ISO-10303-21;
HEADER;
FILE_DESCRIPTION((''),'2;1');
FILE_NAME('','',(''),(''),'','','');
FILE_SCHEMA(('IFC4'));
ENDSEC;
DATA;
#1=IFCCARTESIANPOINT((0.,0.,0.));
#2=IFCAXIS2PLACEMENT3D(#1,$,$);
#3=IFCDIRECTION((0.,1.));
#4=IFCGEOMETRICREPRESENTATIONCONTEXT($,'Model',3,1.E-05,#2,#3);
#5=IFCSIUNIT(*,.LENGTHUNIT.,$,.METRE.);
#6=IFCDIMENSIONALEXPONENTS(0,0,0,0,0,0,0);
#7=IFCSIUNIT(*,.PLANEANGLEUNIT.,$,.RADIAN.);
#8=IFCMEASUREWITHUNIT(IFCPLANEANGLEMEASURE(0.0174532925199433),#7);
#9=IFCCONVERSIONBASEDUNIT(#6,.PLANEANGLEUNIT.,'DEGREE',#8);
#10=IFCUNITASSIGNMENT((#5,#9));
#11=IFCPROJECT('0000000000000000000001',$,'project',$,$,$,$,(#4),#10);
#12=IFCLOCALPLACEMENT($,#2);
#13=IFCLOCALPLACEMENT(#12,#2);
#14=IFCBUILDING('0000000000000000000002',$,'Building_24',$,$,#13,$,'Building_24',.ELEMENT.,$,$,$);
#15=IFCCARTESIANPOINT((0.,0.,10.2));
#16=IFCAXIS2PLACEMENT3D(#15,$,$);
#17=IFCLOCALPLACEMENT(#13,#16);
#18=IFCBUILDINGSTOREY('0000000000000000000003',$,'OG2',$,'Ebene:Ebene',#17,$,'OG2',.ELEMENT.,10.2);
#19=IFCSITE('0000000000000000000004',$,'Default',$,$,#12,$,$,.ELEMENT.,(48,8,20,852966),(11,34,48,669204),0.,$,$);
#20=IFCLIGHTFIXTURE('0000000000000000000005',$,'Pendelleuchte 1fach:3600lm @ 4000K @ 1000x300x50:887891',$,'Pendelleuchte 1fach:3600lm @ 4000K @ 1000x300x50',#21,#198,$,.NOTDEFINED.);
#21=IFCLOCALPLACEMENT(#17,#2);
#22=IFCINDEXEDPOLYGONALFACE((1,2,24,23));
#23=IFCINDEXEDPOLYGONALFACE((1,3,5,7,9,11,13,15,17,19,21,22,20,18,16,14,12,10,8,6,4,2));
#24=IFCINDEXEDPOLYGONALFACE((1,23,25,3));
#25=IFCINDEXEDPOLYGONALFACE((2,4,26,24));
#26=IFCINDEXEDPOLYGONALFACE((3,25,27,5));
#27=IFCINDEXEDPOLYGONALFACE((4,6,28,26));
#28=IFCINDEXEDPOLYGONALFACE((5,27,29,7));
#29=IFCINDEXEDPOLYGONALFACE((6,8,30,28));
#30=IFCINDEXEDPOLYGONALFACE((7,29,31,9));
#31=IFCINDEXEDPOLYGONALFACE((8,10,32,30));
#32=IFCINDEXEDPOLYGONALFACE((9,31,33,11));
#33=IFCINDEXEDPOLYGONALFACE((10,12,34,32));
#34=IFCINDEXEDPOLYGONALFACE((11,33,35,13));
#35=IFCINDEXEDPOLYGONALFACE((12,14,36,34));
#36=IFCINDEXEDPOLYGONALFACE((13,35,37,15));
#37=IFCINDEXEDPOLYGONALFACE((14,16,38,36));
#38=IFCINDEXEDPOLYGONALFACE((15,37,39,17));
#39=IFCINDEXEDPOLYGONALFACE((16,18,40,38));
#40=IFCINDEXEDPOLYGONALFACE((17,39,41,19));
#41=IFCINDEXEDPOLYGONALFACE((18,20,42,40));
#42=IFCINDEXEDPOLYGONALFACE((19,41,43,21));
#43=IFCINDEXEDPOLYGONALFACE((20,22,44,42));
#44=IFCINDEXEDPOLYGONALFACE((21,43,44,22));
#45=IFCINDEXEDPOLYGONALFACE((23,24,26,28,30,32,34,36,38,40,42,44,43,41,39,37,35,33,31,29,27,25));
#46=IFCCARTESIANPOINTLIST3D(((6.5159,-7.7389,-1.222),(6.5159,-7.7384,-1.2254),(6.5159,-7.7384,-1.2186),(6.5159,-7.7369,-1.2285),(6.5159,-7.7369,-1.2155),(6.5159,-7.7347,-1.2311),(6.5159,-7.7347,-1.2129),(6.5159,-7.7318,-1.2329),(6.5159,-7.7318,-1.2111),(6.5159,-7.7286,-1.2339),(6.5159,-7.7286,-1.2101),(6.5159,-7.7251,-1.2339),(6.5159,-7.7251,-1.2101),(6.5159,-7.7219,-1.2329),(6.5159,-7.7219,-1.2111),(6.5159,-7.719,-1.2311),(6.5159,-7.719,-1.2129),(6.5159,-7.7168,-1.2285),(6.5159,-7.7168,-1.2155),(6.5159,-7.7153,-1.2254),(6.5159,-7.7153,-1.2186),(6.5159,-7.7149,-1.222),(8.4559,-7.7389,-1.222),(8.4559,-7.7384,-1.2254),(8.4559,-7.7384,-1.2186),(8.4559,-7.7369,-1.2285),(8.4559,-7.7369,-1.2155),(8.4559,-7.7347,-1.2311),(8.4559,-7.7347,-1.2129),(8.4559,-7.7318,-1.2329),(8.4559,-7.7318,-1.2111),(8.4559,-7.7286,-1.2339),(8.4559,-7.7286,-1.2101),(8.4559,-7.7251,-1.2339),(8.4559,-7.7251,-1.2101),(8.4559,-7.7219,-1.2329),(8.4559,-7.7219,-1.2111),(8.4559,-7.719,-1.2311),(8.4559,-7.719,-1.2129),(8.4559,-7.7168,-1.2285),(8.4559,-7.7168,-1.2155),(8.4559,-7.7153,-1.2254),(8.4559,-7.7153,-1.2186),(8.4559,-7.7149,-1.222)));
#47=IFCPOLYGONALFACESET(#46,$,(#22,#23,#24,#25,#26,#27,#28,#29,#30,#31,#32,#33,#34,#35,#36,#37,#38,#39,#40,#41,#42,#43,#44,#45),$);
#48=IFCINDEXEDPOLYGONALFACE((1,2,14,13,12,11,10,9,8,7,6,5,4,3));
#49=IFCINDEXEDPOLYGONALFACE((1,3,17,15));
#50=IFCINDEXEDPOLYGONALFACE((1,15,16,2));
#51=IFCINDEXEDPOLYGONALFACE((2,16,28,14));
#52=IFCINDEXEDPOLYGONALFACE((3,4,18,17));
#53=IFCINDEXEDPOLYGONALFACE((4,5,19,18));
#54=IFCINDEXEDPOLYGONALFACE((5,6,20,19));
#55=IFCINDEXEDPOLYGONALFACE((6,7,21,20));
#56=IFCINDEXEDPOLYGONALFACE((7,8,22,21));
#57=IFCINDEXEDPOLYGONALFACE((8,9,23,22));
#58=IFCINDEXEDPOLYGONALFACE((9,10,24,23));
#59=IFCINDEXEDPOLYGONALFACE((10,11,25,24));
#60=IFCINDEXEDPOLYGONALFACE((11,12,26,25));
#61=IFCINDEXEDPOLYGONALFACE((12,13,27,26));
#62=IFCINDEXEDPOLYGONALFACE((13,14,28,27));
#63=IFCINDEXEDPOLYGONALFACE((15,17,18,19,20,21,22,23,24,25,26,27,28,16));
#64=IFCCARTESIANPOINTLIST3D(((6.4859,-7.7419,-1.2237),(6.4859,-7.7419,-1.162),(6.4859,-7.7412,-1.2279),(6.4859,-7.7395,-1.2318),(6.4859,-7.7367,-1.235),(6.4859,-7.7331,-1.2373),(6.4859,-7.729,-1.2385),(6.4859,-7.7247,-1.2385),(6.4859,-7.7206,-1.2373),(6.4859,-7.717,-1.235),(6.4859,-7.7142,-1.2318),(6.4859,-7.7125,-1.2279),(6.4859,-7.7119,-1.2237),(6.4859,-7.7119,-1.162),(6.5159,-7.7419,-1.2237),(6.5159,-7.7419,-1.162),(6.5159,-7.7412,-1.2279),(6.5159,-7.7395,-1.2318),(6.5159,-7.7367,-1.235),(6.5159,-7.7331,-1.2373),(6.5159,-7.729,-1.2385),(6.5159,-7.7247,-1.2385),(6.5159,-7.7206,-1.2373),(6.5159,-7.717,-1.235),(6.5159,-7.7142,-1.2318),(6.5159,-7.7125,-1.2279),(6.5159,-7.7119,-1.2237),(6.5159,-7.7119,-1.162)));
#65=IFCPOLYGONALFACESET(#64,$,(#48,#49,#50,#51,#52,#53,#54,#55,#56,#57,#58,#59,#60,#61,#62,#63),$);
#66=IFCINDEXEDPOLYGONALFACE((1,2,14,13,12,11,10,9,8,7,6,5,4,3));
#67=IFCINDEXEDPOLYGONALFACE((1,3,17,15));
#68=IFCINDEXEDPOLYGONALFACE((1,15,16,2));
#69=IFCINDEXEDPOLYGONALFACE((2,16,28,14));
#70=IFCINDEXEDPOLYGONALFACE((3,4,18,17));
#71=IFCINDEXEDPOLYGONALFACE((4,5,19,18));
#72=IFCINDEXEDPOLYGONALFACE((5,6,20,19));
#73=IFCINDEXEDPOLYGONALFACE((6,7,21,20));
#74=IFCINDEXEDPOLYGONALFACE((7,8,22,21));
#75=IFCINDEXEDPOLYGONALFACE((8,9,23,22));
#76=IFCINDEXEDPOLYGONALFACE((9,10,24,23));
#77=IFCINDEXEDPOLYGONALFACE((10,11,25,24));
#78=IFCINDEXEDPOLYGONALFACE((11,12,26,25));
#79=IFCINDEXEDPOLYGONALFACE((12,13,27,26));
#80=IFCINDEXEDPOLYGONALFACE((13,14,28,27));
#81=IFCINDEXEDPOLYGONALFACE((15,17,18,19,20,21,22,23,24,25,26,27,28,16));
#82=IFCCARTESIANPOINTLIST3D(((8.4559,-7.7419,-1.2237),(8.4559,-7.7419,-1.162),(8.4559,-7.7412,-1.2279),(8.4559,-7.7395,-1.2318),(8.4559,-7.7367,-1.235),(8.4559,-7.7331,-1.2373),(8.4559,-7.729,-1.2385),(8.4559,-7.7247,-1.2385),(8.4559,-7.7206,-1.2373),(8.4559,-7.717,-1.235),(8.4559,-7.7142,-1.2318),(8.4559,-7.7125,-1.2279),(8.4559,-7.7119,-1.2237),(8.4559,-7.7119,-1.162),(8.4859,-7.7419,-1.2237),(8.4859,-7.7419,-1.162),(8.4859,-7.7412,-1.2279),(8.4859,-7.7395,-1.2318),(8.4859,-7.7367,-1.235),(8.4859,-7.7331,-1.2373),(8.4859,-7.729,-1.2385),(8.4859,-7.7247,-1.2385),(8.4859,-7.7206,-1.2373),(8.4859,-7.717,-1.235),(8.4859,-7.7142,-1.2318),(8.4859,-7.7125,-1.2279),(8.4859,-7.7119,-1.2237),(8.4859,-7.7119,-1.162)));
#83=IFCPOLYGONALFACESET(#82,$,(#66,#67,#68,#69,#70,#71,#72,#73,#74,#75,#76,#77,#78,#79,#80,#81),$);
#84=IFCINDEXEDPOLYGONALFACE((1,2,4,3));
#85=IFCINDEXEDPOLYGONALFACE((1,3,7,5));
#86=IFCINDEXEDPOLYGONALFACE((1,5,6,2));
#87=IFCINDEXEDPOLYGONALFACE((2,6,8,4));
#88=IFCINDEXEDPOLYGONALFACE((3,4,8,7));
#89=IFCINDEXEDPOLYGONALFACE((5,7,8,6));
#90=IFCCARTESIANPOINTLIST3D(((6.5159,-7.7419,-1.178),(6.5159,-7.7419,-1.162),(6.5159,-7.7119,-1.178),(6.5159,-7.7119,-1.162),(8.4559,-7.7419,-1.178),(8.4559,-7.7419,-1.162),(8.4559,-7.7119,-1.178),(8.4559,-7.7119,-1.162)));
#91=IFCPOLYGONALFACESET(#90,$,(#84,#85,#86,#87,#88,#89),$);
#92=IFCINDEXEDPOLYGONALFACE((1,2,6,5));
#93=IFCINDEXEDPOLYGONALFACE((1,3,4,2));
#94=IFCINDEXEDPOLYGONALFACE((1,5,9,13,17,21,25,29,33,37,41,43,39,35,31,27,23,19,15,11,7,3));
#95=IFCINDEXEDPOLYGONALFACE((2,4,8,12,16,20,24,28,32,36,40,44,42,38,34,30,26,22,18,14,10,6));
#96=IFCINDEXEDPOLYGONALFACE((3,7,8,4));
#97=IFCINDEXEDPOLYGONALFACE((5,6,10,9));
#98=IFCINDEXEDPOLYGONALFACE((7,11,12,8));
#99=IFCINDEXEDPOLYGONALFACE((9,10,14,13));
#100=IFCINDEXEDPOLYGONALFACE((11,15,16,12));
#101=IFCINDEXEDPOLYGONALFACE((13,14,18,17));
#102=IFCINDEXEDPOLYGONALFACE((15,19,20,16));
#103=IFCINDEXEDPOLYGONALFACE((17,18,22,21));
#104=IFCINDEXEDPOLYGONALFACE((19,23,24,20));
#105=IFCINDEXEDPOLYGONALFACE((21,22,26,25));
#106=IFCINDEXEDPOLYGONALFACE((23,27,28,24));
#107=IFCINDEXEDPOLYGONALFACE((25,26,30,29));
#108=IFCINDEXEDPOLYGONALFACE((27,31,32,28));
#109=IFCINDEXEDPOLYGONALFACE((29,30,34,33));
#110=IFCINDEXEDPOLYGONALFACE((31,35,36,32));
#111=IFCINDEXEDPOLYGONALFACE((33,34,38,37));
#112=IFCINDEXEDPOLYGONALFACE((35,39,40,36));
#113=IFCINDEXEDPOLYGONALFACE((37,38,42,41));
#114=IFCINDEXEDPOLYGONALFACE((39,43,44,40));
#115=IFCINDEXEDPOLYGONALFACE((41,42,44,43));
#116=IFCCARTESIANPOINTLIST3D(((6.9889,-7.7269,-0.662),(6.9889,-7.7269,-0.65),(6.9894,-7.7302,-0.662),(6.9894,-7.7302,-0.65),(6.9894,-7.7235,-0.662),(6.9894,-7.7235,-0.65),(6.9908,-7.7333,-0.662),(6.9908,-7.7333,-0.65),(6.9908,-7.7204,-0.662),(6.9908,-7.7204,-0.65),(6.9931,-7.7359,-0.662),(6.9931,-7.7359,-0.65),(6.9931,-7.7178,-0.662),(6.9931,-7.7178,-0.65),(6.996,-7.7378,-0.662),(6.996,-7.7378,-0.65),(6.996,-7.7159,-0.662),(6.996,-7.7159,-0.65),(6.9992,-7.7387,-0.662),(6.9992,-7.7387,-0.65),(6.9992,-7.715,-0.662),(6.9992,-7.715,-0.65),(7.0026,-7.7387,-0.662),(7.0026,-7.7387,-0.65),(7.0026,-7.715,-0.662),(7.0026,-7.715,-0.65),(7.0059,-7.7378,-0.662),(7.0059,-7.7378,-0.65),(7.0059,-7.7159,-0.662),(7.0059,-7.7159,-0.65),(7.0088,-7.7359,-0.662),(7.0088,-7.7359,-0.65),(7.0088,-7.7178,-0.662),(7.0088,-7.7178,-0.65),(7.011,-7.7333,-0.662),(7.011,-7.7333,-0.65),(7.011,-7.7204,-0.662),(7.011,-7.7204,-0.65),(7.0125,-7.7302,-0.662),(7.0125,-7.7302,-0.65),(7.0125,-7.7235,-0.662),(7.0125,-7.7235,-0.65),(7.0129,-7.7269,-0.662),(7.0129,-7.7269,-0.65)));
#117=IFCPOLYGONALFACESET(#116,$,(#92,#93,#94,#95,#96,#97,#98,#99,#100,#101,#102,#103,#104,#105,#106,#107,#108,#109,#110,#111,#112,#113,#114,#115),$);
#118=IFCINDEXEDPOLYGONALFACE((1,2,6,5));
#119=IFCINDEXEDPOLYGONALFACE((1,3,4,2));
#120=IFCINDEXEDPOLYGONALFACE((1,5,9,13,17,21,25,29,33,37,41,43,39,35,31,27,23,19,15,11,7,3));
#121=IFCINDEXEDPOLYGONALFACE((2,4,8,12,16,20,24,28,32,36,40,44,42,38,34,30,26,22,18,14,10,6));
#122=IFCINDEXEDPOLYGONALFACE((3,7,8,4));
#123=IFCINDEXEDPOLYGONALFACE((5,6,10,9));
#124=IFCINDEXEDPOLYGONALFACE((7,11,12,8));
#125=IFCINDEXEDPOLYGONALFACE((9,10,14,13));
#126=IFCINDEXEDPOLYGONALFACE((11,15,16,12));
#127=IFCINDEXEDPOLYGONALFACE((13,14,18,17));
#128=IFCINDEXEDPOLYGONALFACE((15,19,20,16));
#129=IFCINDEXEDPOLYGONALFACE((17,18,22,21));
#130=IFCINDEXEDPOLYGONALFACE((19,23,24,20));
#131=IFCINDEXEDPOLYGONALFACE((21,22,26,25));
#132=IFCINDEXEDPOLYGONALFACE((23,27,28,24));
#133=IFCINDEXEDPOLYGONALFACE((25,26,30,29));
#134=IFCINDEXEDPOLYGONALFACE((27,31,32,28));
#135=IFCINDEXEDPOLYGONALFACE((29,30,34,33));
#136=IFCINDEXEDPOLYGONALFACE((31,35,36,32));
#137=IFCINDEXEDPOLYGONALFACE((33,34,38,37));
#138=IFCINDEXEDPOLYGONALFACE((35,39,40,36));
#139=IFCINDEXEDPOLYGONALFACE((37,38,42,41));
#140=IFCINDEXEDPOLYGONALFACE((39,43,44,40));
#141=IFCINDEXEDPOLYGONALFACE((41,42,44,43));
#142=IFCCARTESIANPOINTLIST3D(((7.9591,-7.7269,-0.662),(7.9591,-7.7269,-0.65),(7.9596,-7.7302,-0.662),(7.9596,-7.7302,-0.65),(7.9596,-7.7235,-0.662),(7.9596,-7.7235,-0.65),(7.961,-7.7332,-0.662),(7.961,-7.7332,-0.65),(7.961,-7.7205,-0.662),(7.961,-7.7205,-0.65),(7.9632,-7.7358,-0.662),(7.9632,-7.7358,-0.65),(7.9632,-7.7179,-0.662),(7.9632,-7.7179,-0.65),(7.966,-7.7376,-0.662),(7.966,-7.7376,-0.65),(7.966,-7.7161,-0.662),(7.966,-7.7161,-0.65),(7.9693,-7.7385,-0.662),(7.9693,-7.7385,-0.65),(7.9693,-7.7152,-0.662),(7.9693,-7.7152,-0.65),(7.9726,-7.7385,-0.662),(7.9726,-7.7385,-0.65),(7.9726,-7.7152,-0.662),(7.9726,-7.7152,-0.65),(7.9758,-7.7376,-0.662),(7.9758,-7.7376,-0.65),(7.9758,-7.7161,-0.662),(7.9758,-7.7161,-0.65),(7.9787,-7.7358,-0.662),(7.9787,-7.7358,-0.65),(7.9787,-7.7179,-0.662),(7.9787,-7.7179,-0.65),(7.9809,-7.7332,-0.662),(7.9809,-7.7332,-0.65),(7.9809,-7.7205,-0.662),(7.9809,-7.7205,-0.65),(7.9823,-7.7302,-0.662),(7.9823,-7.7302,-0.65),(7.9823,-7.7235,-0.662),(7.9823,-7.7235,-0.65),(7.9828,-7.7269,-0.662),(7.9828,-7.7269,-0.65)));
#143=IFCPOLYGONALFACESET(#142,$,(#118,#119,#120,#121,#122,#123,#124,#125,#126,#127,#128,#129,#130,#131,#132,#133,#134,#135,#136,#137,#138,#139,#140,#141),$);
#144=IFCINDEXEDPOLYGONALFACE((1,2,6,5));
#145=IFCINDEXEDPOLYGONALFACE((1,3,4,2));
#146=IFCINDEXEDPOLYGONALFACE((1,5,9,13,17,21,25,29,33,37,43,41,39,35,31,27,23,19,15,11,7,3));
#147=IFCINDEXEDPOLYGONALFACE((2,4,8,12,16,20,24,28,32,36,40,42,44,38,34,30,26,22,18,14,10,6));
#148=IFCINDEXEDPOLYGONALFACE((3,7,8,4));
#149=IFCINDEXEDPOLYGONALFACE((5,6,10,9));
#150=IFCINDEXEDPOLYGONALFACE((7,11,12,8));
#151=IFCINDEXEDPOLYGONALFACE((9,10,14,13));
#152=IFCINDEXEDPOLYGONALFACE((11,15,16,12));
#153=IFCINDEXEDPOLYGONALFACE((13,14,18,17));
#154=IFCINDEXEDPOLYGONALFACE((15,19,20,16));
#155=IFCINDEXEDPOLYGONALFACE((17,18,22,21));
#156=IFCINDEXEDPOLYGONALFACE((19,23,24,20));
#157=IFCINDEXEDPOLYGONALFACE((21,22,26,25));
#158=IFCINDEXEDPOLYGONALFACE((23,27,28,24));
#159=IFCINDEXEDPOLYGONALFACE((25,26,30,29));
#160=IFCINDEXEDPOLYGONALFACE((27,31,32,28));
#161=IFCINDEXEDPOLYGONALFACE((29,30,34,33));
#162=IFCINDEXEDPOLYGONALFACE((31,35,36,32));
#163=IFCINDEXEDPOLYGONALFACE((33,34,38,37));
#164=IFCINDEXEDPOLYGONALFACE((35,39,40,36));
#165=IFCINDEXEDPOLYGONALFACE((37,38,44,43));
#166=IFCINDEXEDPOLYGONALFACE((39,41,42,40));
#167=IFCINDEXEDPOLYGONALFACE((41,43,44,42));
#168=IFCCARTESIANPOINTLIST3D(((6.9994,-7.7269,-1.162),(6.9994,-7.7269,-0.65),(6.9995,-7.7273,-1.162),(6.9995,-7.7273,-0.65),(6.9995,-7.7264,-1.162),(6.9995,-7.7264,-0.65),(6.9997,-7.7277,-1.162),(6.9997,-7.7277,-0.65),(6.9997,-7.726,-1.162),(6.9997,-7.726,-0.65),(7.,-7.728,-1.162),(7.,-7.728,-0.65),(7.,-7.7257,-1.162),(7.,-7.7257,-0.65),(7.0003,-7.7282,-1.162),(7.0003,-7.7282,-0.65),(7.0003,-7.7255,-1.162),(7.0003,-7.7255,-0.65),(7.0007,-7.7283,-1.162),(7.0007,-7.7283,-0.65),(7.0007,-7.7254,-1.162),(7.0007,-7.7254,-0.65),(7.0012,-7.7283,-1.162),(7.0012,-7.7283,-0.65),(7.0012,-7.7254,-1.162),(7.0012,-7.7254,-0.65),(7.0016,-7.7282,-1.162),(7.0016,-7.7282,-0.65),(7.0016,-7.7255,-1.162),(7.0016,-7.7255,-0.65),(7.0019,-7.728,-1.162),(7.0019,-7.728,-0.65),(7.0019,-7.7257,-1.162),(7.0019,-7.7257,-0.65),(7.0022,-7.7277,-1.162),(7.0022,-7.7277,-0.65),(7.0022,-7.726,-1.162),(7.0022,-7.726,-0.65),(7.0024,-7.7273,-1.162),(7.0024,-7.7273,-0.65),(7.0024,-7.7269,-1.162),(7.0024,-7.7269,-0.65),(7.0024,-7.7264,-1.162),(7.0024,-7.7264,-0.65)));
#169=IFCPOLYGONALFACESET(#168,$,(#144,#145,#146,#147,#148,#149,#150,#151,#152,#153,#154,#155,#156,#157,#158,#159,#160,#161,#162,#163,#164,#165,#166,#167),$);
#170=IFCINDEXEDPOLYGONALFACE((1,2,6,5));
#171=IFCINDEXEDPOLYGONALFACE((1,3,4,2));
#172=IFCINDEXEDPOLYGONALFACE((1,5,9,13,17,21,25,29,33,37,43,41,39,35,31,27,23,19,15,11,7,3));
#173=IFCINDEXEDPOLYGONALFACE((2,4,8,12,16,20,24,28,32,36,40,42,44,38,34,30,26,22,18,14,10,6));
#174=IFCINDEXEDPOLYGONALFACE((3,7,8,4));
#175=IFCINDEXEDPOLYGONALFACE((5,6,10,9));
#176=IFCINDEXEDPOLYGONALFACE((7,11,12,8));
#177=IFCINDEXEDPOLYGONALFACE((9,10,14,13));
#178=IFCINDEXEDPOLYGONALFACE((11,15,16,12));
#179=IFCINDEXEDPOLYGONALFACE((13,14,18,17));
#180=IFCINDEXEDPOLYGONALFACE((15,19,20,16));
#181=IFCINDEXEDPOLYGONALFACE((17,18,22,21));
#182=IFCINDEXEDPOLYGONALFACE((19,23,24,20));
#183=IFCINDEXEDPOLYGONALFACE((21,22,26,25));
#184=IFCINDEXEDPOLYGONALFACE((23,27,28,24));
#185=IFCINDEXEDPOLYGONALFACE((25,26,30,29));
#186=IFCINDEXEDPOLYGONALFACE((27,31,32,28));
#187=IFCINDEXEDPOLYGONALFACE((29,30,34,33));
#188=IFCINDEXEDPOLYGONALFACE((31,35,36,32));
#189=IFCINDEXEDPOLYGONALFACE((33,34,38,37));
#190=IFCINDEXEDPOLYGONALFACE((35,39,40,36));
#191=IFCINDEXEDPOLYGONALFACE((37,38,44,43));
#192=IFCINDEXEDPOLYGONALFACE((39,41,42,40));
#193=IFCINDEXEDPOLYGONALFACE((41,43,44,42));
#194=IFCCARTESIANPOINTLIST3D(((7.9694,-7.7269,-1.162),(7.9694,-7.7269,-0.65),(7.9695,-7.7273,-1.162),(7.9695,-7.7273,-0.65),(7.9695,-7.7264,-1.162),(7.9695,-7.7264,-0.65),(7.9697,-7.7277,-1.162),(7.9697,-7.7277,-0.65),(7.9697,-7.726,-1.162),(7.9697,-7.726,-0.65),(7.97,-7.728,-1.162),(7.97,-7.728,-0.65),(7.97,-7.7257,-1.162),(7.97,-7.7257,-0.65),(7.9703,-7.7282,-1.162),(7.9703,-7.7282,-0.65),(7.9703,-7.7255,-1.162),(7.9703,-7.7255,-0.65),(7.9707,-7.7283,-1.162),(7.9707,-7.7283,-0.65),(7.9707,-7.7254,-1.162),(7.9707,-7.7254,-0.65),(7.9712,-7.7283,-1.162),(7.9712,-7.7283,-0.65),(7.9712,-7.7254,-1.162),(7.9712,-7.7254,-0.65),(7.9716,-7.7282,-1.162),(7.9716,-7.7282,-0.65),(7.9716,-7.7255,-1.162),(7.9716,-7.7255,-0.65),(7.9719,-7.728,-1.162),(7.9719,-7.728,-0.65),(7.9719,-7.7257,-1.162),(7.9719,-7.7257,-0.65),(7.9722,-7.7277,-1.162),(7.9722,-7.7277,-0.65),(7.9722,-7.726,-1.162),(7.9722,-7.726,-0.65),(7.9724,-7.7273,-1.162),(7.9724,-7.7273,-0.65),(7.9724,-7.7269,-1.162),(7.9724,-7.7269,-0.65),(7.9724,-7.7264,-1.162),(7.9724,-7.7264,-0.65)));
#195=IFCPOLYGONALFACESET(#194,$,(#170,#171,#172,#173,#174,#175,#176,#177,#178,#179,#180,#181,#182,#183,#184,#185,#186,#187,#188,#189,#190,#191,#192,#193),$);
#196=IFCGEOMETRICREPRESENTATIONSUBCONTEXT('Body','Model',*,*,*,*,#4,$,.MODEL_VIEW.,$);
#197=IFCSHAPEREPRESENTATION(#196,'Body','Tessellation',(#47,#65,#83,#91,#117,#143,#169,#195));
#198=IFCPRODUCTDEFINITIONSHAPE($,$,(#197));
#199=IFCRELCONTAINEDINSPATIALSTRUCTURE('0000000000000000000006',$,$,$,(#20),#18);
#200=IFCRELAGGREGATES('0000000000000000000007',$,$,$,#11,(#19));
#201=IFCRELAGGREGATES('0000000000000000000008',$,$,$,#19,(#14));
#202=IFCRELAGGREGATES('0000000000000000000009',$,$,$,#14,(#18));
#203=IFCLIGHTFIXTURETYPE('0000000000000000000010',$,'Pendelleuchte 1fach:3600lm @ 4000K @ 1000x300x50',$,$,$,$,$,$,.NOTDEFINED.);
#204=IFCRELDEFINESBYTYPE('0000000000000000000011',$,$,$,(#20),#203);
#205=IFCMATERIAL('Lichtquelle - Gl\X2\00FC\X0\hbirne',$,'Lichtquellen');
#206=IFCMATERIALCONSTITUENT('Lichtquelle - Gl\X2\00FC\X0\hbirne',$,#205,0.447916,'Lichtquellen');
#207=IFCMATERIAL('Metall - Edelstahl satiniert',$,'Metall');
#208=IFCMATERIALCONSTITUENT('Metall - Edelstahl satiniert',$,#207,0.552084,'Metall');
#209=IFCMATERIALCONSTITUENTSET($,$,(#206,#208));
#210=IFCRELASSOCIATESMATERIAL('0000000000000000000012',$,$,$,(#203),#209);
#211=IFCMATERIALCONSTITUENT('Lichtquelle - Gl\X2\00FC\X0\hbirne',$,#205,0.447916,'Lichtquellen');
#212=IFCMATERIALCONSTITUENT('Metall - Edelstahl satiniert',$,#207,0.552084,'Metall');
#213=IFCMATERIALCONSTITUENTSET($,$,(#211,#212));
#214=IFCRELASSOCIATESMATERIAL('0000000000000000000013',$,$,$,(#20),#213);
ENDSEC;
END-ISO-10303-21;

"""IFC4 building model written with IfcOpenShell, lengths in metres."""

from ifc_helpers import new_model, entity, si_unit, converted_unit, direction, frame, origin, place, context, subcontext, project, spatial, line, arc, indexed_curve, outline, extrude, source, transform, mapped, material, constituent, constituent_set, type_object, type_shapes, element, save


model = new_model("IFC4")

# Units and contexts
model_context = context("Model", 3, precision=1e-05, world=origin(), true_north=direction((0.0, 1.0)))
body_context = subcontext(model_context, "Body", "Model", "MODEL_VIEW")
ifc_project = project(units=[si_unit("LENGTHUNIT", "METRE"), converted_unit("PLANEANGLEUNIT", "DEGREE", entity("IfcPlaneAngleMeasure", 0.0174532925199433), si_unit("PLANEANGLEUNIT", "RADIAN"), dimensions=[0, 0, 0, 0, 0, 0, 0])], contexts=[model_context])

# Site, building, storey
site_placement = place(None, origin())
site = spatial("IfcSite", under=ifc_project, at=site_placement, Name="Default", CompositionType="ELEMENT", RefLatitude=(48, 8, 20, 852966), RefLongitude=(11, 34, 48, 669204), RefElevation=0.0)
building_placement = place(site_placement, origin())
building = spatial("IfcBuilding", under=site, at=building_placement, Name="Building_24", LongName="Building_24", CompositionType="ELEMENT")
storey_placement = place(building_placement, frame((0.0, 0.0, 10.2)))
storey = spatial("IfcBuildingStorey", under=building, at=storey_placement, Name="OG2", ObjectType="Ebene:Ebene", LongName="OG2", CompositionType="ELEMENT", Elevation=10.2)

# Light fixture
ifc_material_1 = material(Name="Lichtquelle - Glühbirne", Category="Lichtquellen")
ifc_material_2 = material(Name="Metall - Edelstahl satiniert", Category="Metall")
ifc_constituent_1 = constituent(ifc_material_1, Name="Lichtquelle - Glühbirne", Category="Lichtquellen", fraction=0.447916)
ifc_constituent_2 = constituent(ifc_material_2, Name="Metall - Edelstahl satiniert", Category="Metall", fraction=0.552084)
ifc_constituent_set_1 = constituent_set(constituents=[ifc_constituent_1, ifc_constituent_2])
light_fixture_type_1 = type_object("IfcLightFixtureType", Name="Pendelleuchte 1fach:3600lm @ 4000K @ 1000x300x50", PredefinedType="NOTDEFINED", material=ifc_constituent_set_1)
shared_shape_1 = source(origin(), body_context, "Body", "SweptSolid", [
    extrude(outline(indexed_curve([(-0.012, 0.0), (0.0, -0.012), (0.012, 0.0), (0.0, 0.012)], segments=[arc(1, 2, 3), arc(3, 4, 1)], self_intersect=False)), frame((-0.97, 0.0, -0.572), z_axis=(1.0, 0.0, 0.0), x_axis=(0.0, 1.0, 0.0)), (0.0, 0.0, 1.0), 1.94),
    extrude(outline(indexed_curve([(-0.0308, -0.015), (0.0308, -0.015), (0.0308, 0.015), (-0.0308, 0.015), (-0.0458, 0.0)], segments=[line(1, 2, 3, 4), arc(4, 5, 1)], self_intersect=False)), frame((0.97, 0.0, -0.5428), z_axis=(1.0, 0.0, 0.0), x_axis=(0.0, 0.0, 1.0)), (0.0, 0.0, 1.0), 0.03),
    extrude(outline(indexed_curve([(-0.0308, -0.015), (0.0308, -0.015), (0.0308, 0.015), (-0.0308, 0.015), (-0.0458, 0.0)], segments=[line(1, 2, 3, 4), arc(4, 5, 1)], self_intersect=False)), frame((-1.0, 0.0, -0.5428), z_axis=(1.0, 0.0, 0.0), x_axis=(0.0, 0.0, 1.0)), (0.0, 0.0, 1.0), 0.03),
    extrude(outline(indexed_curve([(-0.97, -0.015), (0.97, -0.015), (0.97, 0.015), (-0.97, 0.015), (-0.97, -0.015)], self_intersect=False)), frame((0.0, 0.0, -0.528), z_axis=(0.0, 0.0, 1.0), x_axis=(-1.0, 0.0, 0.0)), (0.0, 0.0, 1.0), 0.016),
    extrude(outline(indexed_curve([(-0.012, 0.0), (0.0, -0.012), (0.012, 0.0), (0.0, 0.012)], segments=[arc(1, 2, 3), arc(3, 4, 1)], self_intersect=False)), frame((0.485, 0.0, -0.012)), (0.0, 0.0, 1.0), 0.012),
    extrude(outline(indexed_curve([(-0.0118, 0.0), (0.0, -0.0118), (0.0118, 0.0), (0.0, 0.0118)], segments=[arc(1, 2, 3), arc(3, 4, 1)], self_intersect=False)), frame((-0.485, 0.0, -0.012)), (0.0, 0.0, 1.0), 0.012),
    extrude(outline(indexed_curve([(-0.0015, 0.0), (0.0, -0.0015), (0.0015, 0.0), (0.0, 0.0015)], segments=[arc(1, 2, 3), arc(3, 4, 1)], self_intersect=False)), frame((0.485, 0.0, -0.512)), (0.0, 0.0, 1.0), 0.512),
    extrude(outline(indexed_curve([(-0.0015, 0.0), (0.0, -0.0015), (0.0015, 0.0), (0.0, 0.0015)], segments=[arc(1, 2, 3), arc(3, 4, 1)], self_intersect=False)), frame((-0.485, 0.0, -0.512)), (0.0, 0.0, 1.0), 0.512),
])
type_shapes(light_fixture_type_1, [shared_shape_1])
ifc_constituent_3 = constituent(ifc_material_1, Name="Lichtquelle - Glühbirne", Category="Lichtquellen", fraction=0.447916)
ifc_constituent_4 = constituent(ifc_material_2, Name="Metall - Edelstahl satiniert", Category="Metall", fraction=0.552084)
ifc_constituent_set_2 = constituent_set(constituents=[ifc_constituent_3, ifc_constituent_4])
light_fixture_1_placement = place(storey_placement, frame((7.4859, -7.7269, -0.65), z_axis=(0.0, 0.0, 1.0), x_axis=(-1.0, 0.0, 0.0)))
element("IfcLightFixture", 1, at=light_fixture_1_placement, inside=storey, type_object=light_fixture_type_1, material=ifc_constituent_set_2, Name="Pendelleuchte 1fach:3600lm @ 4000K @ 1000x300x50:887891", ObjectType="Pendelleuchte 1fach:3600lm @ 4000K @ 1000x300x50", PredefinedType="NOTDEFINED", context=body_context, shape_type="MappedRepresentation", body=[
    mapped(shared_shape_1, transform((0.0, 0.0, 0.0), scale=1.0)),
])

save(model, "model.ifc")
